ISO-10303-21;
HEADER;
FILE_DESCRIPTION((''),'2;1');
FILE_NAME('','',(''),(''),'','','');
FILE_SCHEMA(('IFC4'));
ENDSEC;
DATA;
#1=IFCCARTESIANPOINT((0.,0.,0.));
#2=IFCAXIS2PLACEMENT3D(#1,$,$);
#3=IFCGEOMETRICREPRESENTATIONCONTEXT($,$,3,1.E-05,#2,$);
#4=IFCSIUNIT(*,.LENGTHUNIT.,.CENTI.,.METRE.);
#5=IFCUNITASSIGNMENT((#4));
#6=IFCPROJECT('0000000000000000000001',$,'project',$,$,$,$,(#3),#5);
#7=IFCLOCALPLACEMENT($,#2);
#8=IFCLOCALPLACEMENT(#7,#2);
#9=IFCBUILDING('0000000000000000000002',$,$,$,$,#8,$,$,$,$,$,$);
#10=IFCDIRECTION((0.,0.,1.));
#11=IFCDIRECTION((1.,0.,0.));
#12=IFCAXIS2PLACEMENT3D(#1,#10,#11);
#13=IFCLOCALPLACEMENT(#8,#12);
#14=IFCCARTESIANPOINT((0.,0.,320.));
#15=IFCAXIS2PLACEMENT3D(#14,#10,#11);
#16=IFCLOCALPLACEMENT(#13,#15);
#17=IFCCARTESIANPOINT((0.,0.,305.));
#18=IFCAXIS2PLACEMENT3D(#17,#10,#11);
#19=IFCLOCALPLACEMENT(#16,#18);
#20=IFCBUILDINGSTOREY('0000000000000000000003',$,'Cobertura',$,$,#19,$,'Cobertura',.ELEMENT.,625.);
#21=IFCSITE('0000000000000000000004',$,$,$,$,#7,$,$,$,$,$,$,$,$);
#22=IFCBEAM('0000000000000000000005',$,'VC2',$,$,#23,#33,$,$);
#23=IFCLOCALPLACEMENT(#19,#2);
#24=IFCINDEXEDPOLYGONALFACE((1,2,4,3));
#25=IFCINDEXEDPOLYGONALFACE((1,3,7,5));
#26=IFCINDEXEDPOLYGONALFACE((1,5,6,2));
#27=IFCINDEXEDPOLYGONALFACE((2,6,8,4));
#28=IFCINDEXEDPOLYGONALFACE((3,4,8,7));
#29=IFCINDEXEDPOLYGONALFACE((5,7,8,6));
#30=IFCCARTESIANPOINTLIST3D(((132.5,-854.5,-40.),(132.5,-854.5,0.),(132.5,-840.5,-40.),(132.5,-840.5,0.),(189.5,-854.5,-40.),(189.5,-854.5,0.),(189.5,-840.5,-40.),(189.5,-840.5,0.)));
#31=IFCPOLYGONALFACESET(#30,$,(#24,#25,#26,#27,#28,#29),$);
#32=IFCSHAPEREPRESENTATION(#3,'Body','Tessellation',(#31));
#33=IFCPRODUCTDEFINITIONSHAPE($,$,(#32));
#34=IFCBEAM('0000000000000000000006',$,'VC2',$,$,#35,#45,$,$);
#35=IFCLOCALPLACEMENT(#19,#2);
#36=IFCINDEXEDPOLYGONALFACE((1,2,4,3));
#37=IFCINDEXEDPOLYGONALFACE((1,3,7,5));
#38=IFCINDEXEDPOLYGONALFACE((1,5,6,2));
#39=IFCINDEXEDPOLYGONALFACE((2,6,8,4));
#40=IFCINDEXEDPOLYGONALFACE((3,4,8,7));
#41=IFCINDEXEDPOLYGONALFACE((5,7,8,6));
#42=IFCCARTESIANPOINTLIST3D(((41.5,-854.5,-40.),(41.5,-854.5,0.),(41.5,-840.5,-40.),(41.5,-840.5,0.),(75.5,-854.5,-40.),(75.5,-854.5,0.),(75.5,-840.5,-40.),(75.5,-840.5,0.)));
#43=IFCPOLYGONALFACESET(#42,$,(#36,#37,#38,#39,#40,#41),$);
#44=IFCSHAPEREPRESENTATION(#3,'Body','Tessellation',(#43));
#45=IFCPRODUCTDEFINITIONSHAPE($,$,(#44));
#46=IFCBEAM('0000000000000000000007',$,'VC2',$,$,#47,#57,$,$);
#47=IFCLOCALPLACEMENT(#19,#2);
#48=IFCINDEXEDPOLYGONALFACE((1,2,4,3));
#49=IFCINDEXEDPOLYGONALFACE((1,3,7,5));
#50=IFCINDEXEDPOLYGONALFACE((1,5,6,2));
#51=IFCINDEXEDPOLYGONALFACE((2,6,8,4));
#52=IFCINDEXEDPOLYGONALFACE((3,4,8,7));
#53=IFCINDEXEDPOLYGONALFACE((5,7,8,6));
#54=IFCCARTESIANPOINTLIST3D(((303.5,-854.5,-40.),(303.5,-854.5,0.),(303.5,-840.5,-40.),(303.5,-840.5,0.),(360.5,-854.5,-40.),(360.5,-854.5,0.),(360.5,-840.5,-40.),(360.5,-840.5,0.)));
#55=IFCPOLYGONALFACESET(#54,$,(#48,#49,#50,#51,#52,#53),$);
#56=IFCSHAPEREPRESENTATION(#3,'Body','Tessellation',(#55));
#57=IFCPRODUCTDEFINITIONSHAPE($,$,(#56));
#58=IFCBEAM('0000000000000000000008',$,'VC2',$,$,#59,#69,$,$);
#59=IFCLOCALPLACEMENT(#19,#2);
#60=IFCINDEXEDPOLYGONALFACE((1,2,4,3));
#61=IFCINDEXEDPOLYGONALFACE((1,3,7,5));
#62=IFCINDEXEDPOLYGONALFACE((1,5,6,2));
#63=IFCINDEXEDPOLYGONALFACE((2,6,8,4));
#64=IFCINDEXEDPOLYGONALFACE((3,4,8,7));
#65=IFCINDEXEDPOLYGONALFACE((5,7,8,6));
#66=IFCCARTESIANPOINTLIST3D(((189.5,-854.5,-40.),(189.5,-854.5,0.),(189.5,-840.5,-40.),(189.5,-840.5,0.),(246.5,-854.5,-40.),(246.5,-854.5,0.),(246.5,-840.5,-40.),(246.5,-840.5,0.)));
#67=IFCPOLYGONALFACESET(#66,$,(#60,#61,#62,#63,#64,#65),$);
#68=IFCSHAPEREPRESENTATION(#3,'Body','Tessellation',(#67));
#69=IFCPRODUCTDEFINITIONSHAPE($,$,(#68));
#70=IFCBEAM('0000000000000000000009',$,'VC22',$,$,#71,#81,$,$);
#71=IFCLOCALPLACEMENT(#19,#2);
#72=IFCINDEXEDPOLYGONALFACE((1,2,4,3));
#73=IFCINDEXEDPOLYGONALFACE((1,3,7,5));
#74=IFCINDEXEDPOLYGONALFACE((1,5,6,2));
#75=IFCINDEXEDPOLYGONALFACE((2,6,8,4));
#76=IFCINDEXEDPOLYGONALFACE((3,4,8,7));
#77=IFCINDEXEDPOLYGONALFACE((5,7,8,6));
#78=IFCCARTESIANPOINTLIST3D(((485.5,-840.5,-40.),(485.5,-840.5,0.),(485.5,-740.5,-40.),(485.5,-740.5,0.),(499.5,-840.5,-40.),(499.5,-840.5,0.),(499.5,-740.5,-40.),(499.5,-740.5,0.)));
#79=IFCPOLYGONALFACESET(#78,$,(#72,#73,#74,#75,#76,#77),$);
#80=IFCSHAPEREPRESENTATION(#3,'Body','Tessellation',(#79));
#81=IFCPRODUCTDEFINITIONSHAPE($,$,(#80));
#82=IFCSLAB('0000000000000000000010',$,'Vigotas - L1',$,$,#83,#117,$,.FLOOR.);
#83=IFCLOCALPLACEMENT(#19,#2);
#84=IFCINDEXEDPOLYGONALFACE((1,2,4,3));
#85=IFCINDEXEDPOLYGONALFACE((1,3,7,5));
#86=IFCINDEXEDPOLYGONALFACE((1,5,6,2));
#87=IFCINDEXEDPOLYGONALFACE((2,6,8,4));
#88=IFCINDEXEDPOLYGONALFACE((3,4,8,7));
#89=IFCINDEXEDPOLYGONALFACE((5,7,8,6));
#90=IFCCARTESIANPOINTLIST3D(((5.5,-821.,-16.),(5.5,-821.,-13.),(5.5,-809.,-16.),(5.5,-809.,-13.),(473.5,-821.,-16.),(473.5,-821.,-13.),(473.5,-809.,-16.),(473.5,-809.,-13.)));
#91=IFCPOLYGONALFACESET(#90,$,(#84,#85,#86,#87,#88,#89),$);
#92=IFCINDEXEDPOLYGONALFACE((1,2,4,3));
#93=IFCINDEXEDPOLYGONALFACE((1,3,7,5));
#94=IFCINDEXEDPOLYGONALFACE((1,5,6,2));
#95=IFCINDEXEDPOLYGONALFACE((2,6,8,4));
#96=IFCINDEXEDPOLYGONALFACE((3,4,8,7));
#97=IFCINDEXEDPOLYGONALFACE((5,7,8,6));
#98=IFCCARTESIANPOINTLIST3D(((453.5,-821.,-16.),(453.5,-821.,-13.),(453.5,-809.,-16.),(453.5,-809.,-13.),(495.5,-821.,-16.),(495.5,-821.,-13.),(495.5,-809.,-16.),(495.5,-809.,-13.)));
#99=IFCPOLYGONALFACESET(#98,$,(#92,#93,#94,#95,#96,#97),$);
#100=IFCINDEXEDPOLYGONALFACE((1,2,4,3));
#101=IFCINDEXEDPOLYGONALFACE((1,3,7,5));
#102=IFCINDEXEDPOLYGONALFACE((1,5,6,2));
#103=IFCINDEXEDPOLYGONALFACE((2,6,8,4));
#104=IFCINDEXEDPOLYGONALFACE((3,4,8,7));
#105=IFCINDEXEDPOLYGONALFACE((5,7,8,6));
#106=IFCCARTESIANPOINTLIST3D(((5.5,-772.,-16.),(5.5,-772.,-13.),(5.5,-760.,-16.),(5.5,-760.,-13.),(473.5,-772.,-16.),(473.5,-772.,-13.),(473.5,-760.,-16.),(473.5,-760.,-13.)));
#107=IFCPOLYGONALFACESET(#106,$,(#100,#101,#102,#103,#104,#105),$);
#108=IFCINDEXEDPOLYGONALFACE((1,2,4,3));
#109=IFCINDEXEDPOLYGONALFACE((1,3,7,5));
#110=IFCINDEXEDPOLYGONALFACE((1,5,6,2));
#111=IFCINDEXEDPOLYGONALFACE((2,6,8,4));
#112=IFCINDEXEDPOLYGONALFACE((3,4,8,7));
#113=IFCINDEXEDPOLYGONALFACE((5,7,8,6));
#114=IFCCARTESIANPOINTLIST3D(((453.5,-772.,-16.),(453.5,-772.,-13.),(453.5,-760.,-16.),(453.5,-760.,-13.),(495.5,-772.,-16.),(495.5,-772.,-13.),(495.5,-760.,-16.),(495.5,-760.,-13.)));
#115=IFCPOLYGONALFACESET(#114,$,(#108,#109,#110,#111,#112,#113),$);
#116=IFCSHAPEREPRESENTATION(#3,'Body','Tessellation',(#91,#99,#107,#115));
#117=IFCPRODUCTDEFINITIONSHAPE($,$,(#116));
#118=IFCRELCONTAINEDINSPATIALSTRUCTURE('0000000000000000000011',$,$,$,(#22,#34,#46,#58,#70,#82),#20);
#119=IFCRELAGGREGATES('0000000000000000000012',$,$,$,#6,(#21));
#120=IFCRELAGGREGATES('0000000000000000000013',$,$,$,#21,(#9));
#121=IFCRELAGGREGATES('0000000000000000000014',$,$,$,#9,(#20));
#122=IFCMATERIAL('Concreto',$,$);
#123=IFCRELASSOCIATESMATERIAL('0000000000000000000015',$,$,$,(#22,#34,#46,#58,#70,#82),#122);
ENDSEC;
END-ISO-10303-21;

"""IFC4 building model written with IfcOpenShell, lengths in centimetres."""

from ifc_helpers import new_model, si_unit, frame, origin, origin_with_axes, place, context, project, spatial, polyline, outline, extrude, material, element, save


model = new_model("IFC4")

# Units and contexts
context_of_model = context(None, 3, precision=1e-05, world=origin())
ifc_project = project(units=[si_unit("LENGTHUNIT", "METRE", prefix="CENTI")], contexts=[context_of_model])

# Site, building, storey
site_placement = place(None, origin())
site = spatial("IfcSite", under=ifc_project, at=site_placement)
building_placement = place(site_placement, origin())
building = spatial("IfcBuilding", under=site, at=building_placement)
placement_1 = place(building_placement, origin_with_axes())
placement_2 = place(placement_1, frame((0.0, 0.0, 320.0), z_axis=(0.0, 0.0, 1.0), x_axis=(1.0, 0.0, 0.0)))
storey_placement = place(placement_2, frame((0.0, 0.0, 305.0), z_axis=(0.0, 0.0, 1.0), x_axis=(1.0, 0.0, 0.0)))
storey = spatial("IfcBuildingStorey", under=building, at=storey_placement, Name="Cobertura", LongName="Cobertura", CompositionType="ELEMENT", Elevation=625.0)

# Shared definitions
ifc_material_1 = material(Name="Concreto")

# Beams
beam_1_placement = place(storey_placement, frame((161.0, -847.5, 0.0), z_axis=(0.0, 0.0, 1.0), x_axis=(1.0, 0.0, 0.0)))
element("IfcBeam", 1, at=beam_1_placement, inside=storey, material=ifc_material_1, Name="VC2", context=context_of_model, shape_type="SolidModel", body=[
    extrude(outline(polyline([(-7.0, -20.0), (7.0, -20.0), (7.0, 20.0), (-7.0, 20.0), (-7.0, -20.0)])), frame((-28.5, 0.0, -20.0), z_axis=(1.0, 0.0, 0.0), x_axis=(0.0, -1.0, 0.0)), (0.0, 0.0, 1.0), 57.0),
])
beam_2_placement = place(storey_placement, frame((58.5, -847.5, 0.0), z_axis=(0.0, 0.0, 1.0), x_axis=(1.0, 0.0, 0.0)))
element("IfcBeam", 2, at=beam_2_placement, inside=storey, material=ifc_material_1, Name="VC2", context=context_of_model, shape_type="SolidModel", body=[
    extrude(outline(polyline([(-7.0, -20.0), (7.0, -20.0), (7.0, 20.0), (-7.0, 20.0), (-7.0, -20.0)])), frame((-17.0, 0.0, -20.0), z_axis=(1.0, 0.0, 0.0), x_axis=(0.0, -1.0, 0.0)), (0.0, 0.0, 1.0), 34.0),
])
for number, where, z_axis, x_axis, name in (
    (3, (332.0, -847.5, 0.0), (0.0, 0.0, 1.0), (1.0, 0.0, 0.0), "VC2"),
    (4, (218.0, -847.5, 0.0), (0.0, 0.0, 1.0), (1.0, 0.0, 0.0), "VC2"),
):
    element("IfcBeam", number, at=place(storey_placement, frame(where, z_axis=z_axis, x_axis=x_axis)), inside=storey, material=ifc_material_1, Name=name, context=context_of_model, shape_type="SolidModel", body=[
        extrude(outline(polyline([(-7.0, -20.0), (7.0, -20.0), (7.0, 20.0), (-7.0, 20.0), (-7.0, -20.0)])), frame((-28.5, 0.0, -20.0), z_axis=(1.0, 0.0, 0.0), x_axis=(0.0, -1.0, 0.0)), (0.0, 0.0, 1.0), 57.0),
    ])
beam_3_placement = place(storey_placement, frame((492.5, -790.5, 0.0), z_axis=(0.0, 0.0, 1.0), x_axis=(1.0, 0.0, 0.0)))
element("IfcBeam", 5, at=beam_3_placement, inside=storey, material=ifc_material_1, Name="VC22", context=context_of_model, shape_type="SolidModel", body=[
    extrude(outline(polyline([(-7.0, -20.0), (7.0, -20.0), (7.0, 20.0), (-7.0, 20.0), (-7.0, -20.0)])), frame((0.0, -50.0, -20.0), z_axis=(0.0, 1.0, 0.0), x_axis=(1.0, 0.0, 0.0)), (0.0, 0.0, 1.0), 100.0),
])

# Slab
slab_placement = place(storey_placement, frame((250.5, -790.5, -13.0), z_axis=(0.0, 0.0, 1.0), x_axis=(1.0, 0.0, 0.0)))
element("IfcSlab", 6, at=slab_placement, inside=storey, material=ifc_material_1, Name="Vigotas - L1", PredefinedType="FLOOR", context=context_of_model, shape_type="SolidModel", body=[
    extrude(outline(polyline([(6.0, 1.5), (-6.0, 1.5), (-6.0, -1.5), (6.0, -1.5), (6.0, 1.5), (6.0, 1.5)])), frame((-245.0, -24.5, -1.5), z_axis=(1.0, 0.0, 0.0), x_axis=(0.0, -1.0, 0.0)), (0.0, 0.0, 1.0), 468.0),
    extrude(outline(polyline([(6.0, 1.5), (-6.0, 1.5), (-6.0, -1.5), (6.0, -1.5), (6.0, 1.5), (6.0, 1.5)])), frame((203.0, -24.5, -1.5), z_axis=(1.0, 0.0, 0.0), x_axis=(0.0, -1.0, 0.0)), (0.0, 0.0, 1.0), 42.0),
    extrude(outline(polyline([(6.0, 1.5), (-6.0, 1.5), (-6.0, -1.5), (6.0, -1.5), (6.0, 1.5), (6.0, 1.5)])), frame((-245.0, 24.5, -1.5), z_axis=(1.0, 0.0, 0.0), x_axis=(0.0, -1.0, 0.0)), (0.0, 0.0, 1.0), 468.0),
    extrude(outline(polyline([(6.0, 1.5), (-6.0, 1.5), (-6.0, -1.5), (6.0, -1.5), (6.0, 1.5), (6.0, 1.5)])), frame((203.0, 24.5, -1.5), z_axis=(1.0, 0.0, 0.0), x_axis=(0.0, -1.0, 0.0)), (0.0, 0.0, 1.0), 42.0),
])

save(model, "model.ifc")
